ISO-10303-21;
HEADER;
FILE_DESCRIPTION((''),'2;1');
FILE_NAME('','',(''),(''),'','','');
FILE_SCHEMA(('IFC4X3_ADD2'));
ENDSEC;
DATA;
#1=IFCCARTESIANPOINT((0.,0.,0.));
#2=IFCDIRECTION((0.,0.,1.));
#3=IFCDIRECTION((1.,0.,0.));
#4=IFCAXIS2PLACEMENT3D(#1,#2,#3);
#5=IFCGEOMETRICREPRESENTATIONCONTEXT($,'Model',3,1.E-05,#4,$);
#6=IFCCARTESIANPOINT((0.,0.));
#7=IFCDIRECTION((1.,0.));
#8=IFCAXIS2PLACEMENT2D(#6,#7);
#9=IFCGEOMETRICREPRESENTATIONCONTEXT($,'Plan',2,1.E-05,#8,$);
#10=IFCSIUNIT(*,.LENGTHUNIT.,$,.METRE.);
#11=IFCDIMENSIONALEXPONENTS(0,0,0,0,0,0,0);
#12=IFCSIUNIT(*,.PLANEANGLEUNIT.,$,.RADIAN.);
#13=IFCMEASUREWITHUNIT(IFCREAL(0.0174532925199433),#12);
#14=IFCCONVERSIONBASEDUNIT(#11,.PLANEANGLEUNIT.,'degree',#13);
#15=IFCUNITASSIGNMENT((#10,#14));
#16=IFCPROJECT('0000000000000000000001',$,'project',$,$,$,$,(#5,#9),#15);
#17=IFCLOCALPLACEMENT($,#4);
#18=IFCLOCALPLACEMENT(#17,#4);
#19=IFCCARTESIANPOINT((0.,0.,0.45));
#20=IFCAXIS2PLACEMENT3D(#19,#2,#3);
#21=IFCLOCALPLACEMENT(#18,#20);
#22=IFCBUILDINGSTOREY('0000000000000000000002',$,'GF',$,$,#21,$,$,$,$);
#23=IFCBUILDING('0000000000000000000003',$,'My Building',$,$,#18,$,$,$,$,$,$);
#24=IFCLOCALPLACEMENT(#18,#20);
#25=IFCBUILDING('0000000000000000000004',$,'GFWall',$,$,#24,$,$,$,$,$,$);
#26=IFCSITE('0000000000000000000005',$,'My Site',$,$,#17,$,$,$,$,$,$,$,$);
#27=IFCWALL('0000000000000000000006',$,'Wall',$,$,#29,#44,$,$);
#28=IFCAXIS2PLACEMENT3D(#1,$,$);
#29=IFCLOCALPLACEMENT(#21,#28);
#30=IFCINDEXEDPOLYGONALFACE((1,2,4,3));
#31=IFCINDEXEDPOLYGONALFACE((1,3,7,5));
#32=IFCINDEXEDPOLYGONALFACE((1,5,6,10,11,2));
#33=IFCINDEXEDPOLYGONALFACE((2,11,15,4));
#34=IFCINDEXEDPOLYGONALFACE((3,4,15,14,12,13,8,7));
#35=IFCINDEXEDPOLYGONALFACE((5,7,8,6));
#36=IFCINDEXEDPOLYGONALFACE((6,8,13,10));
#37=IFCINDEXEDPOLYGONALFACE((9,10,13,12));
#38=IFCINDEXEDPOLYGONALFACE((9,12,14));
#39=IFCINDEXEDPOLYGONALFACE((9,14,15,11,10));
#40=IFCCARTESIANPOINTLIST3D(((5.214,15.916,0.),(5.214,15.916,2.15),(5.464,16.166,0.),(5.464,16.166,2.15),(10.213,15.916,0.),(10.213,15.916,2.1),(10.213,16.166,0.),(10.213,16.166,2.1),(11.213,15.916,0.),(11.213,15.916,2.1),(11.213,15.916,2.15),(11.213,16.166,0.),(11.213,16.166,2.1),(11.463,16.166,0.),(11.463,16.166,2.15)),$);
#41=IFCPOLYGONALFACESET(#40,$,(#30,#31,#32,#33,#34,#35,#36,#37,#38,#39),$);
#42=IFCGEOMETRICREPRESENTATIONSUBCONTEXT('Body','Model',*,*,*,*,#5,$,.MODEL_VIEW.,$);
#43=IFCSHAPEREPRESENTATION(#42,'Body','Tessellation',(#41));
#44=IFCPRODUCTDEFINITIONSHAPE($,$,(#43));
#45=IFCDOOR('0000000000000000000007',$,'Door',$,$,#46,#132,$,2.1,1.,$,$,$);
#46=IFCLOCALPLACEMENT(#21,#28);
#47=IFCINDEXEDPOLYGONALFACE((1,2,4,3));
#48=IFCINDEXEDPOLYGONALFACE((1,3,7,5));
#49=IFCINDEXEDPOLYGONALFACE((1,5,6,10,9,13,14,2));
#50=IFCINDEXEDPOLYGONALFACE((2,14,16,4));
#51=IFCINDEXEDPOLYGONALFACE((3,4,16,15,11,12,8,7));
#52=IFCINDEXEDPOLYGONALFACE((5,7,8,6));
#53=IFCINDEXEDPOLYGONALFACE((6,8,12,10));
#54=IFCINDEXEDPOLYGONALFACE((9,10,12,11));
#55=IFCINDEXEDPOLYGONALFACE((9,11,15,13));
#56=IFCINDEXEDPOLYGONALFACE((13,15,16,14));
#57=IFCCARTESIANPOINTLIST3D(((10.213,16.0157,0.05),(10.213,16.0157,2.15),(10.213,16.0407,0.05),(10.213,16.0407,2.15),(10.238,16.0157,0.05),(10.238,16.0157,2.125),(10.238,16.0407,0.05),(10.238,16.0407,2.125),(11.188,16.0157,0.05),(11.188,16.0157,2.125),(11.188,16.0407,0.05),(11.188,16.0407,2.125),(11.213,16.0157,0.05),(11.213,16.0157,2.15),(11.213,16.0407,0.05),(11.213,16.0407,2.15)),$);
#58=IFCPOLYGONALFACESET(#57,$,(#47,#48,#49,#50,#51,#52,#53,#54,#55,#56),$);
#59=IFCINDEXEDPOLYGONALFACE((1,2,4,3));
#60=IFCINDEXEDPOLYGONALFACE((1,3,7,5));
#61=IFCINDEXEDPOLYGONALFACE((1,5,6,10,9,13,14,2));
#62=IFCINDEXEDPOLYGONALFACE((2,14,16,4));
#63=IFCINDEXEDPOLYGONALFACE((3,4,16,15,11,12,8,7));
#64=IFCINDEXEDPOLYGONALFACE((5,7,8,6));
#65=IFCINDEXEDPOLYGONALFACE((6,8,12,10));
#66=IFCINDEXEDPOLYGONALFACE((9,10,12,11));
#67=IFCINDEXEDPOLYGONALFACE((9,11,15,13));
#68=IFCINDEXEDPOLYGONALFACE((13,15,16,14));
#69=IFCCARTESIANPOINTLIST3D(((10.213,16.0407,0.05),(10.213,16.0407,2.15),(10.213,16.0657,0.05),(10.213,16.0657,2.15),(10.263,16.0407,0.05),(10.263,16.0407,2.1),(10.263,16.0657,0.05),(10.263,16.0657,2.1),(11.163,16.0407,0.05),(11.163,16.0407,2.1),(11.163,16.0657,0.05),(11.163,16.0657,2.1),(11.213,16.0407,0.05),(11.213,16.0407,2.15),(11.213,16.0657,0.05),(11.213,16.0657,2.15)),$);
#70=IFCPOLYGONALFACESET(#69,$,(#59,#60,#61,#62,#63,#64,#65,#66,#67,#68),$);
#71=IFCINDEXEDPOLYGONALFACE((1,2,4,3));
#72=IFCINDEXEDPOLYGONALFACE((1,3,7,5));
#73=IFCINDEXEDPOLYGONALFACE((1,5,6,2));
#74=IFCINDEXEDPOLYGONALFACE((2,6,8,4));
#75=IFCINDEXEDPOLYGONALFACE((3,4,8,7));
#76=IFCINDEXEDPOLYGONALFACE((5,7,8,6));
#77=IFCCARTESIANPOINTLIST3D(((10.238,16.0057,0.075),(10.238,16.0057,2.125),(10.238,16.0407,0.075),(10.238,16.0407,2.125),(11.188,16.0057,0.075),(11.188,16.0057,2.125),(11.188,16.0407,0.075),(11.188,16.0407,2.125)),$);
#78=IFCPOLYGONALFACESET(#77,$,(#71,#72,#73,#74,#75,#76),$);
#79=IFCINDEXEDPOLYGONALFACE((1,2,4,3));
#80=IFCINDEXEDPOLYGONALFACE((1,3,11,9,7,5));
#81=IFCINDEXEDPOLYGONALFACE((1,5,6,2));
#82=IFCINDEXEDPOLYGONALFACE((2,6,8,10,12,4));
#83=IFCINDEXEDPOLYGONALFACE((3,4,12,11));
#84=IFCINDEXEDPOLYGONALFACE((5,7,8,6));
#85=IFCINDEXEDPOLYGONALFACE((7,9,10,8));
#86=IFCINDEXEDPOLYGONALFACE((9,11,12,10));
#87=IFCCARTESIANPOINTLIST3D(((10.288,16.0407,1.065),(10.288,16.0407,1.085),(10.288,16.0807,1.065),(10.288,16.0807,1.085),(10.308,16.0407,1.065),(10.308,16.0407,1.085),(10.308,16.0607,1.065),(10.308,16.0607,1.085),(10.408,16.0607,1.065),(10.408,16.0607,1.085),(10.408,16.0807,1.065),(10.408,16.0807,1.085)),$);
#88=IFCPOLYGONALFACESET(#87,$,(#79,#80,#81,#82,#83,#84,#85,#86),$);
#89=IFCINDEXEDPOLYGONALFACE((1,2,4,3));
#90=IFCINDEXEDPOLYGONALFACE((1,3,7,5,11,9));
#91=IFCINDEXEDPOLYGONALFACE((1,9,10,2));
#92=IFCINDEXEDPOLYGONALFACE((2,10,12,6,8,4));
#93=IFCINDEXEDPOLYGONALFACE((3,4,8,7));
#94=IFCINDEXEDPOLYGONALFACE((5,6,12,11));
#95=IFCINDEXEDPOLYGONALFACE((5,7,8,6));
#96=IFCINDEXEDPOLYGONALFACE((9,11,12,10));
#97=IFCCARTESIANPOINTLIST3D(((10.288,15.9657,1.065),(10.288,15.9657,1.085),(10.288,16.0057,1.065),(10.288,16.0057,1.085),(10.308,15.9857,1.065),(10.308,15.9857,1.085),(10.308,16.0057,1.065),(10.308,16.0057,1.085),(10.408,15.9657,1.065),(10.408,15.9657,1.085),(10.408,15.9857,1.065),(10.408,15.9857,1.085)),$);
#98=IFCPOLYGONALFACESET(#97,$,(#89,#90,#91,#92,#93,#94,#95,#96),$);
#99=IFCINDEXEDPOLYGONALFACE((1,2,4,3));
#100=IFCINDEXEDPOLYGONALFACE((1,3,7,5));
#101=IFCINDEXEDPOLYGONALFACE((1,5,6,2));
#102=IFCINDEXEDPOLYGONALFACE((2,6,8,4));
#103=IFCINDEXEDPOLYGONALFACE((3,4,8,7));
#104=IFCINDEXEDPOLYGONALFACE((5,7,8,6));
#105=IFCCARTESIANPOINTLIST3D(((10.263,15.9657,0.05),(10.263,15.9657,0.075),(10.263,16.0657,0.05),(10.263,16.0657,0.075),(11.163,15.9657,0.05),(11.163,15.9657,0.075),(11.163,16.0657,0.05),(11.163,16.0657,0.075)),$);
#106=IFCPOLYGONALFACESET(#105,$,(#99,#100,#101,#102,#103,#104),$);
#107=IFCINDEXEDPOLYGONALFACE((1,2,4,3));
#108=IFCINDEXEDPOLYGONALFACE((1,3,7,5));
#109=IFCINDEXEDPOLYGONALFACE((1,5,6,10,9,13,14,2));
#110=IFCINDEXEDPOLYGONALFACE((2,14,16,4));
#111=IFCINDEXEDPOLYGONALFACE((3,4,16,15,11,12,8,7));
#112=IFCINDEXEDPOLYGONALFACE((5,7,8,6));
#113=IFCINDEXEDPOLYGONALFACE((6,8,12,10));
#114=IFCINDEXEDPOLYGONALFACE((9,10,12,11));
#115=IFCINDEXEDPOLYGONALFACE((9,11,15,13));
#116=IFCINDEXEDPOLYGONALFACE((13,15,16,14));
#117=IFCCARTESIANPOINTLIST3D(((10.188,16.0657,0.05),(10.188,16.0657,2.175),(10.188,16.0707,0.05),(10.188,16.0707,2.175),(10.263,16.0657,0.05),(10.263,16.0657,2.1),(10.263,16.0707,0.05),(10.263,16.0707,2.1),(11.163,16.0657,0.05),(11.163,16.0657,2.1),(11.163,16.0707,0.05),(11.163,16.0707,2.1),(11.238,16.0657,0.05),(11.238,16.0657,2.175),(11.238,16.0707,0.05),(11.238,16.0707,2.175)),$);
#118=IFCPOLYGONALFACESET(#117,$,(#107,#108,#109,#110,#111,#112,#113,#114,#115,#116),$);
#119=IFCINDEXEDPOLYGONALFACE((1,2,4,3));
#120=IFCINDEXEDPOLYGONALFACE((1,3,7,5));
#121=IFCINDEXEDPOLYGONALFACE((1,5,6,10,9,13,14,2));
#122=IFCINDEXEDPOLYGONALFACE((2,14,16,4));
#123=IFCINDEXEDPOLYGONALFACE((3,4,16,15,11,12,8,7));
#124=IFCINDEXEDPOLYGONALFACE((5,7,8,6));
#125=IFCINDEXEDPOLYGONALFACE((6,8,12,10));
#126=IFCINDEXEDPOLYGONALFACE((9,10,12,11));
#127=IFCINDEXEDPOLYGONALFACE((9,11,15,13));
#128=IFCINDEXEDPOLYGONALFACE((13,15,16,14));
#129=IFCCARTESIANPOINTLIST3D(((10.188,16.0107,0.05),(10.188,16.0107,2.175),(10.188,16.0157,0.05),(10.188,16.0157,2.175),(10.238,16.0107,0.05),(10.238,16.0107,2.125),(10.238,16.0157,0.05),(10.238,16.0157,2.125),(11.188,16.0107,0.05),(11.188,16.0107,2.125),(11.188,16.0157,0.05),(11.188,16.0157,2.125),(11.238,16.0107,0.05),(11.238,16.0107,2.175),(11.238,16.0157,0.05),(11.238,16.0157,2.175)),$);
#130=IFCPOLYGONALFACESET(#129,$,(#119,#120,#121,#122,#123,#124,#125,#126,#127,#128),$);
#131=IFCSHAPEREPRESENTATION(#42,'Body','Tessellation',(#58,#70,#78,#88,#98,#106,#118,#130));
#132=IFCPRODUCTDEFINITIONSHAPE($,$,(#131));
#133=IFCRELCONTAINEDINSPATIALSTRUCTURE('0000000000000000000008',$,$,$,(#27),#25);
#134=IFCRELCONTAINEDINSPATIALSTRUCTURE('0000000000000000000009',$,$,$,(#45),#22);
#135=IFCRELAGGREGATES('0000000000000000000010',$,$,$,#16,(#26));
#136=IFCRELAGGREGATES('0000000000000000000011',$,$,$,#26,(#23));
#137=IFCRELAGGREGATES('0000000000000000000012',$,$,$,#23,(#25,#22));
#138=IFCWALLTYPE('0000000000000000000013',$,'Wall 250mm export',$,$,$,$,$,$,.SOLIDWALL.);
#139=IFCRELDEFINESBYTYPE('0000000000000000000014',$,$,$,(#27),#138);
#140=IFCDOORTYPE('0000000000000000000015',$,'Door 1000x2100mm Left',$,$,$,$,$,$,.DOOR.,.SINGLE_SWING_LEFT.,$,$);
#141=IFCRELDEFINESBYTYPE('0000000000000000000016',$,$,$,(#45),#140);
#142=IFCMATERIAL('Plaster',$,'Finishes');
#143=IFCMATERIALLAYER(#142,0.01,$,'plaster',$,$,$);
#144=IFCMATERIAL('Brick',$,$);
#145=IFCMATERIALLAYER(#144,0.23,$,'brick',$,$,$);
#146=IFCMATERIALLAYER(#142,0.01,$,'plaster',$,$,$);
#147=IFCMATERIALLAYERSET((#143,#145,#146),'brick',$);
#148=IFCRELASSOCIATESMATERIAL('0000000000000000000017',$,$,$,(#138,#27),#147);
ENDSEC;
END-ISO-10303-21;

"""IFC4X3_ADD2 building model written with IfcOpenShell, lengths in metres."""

from ifc_helpers import new_model, entity, si_unit, converted_unit, frame, origin_with_axes, origin_2d_with_axis, place, context, subcontext, project, spatial, line, indexed_curve, outline, extrude, shape, source, transform, mapped, material, layer, layer_set, layer_usage, type_object, type_shapes, element, fill, save


model = new_model("IFC4X3_ADD2")

# Units and contexts
model_context = context("Model", 3, precision=1e-05, world=origin_with_axes())
plan_context = context("Plan", 2, precision=1e-05, world=origin_2d_with_axis())
body_context_1 = subcontext(model_context, "Body", "Model", "MODEL_VIEW")
body_context_2 = subcontext(plan_context, "Body", "Plan", "PLAN_VIEW")
ifc_project = project(units=[si_unit("LENGTHUNIT", "METRE"), converted_unit("PLANEANGLEUNIT", "degree", entity("IfcReal", 0.0174532925199433), si_unit("PLANEANGLEUNIT", "RADIAN"), dimensions=[0, 0, 0, 0, 0, 0, 0])], contexts=[model_context, plan_context])

# Site, buildings
site_placement = place(None, origin_with_axes())
site = spatial("IfcSite", under=ifc_project, at=site_placement, Name="My Site")
building_1_placement = place(site_placement, origin_with_axes())
building_1 = spatial("IfcBuilding", under=site, at=building_1_placement, Name="My Building")
building_2_placement = place(building_1_placement, frame((0.0, 0.0, 0.45), z_axis=(0.0, 0.0, 1.0), x_axis=(1.0, 0.0, 0.0)))
building_2 = spatial("IfcBuilding", under=building_1, at=building_2_placement, Name="GFWall")

# Shared definitions
ifc_material_1 = material(Name="Plaster", Category="Finishes")

# Shared definitions
storey_placement = place(building_1_placement, frame((0.0, 0.0, 0.45), z_axis=(0.0, 0.0, 1.0), x_axis=(1.0, 0.0, 0.0)))
storey = spatial("IfcBuildingStorey", under=building_1, at=storey_placement, Name="GF")

# Shared definitions
ifc_layer_1 = layer(ifc_material_1, 0.01, Name="plaster")
ifc_material_2 = material(Name="Brick")
ifc_layer_2 = layer(ifc_material_2, 0.23, Name="brick")
ifc_layer_3 = layer(ifc_material_1, 0.01, Name="plaster")
ifc_layer_set_1 = layer_set([ifc_layer_1, ifc_layer_2, ifc_layer_3], Name="brick")
wall_type_1 = type_object("IfcWallType", Name="Wall 250mm export", PredefinedType="SOLIDWALL", material=ifc_layer_set_1)

# Wall, opening, door
ifc_layer_usage_1 = layer_usage(ifc_layer_set_1, "AXIS2", "POSITIVE", 0.0)
wall_1_placement = place(building_2_placement, frame((5.464, 15.916, 0.0), z_axis=(0.0, 0.0, 1.0), x_axis=(1.0, 0.0, 0.0)))
wall_1 = element("IfcWall", 1, at=wall_1_placement, inside=building_2, type_object=wall_type_1, material=ifc_layer_usage_1, Name="Wall", context=body_context_1, shape_type="SweptSolid", body=[
    extrude(outline(indexed_curve([(-0.25, 0.0), (0.0, 0.25), (5.999, 0.25), (5.749, 0.0)], segments=[line(1, 2, 3, 4, 1)])), origin_with_axes(), (0.0, 0.0, 1.0), 2.15),
])
shared_shape_1 = source(origin_with_axes(), body_context_1, "Body", "SweptSolid", [
    extrude(outline(indexed_curve([(0.0, 0.0), (1.0, 0.0), (1.0, 2.1), (0.0, 2.1)], segments=[line(1, 2, 3, 4, 1)])), frame((0.0, -0.6, 0.0), z_axis=(0.0, -1.0, 0.0), x_axis=(1.0, 0.0, 0.0)), (0.0, 0.0, -1.0), 1.2),
])
opening_1_placement = place(wall_1_placement, frame((5.749, 0.1497, 0.0), z_axis=(0.0, 0.0, 1.0), x_axis=(-1.0, 0.0, 0.0)))
opening_1 = element("IfcOpeningElement", 2, at=opening_1_placement, cuts=wall_1, PredefinedType="OPENING", context=body_context_1, shape_type="MappedRepresentation", body=[
    mapped(shared_shape_1, transform((0.0, 0.0, 0.0), x_axis=(1.0, 0.0, 0.0), y_axis=(0.0, 1.0, 0.0), z_axis=(0.0, 0.0, 1.0), scale=1.0)),
])
door_type_1 = type_object("IfcDoorType", Name="Door 1000x2100mm Left", OperationType="SINGLE_SWING_LEFT", PredefinedType="DOOR")
shared_shape_2 = source(origin_with_axes(), body_context_1, "Body", "SweptSolid", [
    extrude(outline(indexed_curve([(0.0, 0.0), (0.0, 2.1), (1.0, 2.1), (1.0, 0.0), (0.975, 0.0), (0.975, 2.075), (0.025, 2.075), (0.025, 0.0)], segments=[line(1, 2, 3, 4, 5, 6, 7, 8, 1)])), frame((0.0, 0.025, 0.0), z_axis=(0.0, -1.0, 0.0), x_axis=(1.0, 0.0, 0.0)), (0.0, 0.0, -1.0), 0.025),
    extrude(outline(indexed_curve([(0.0, 0.0), (0.0, 2.1), (1.0, 2.1), (1.0, 0.0), (0.95, 0.0), (0.95, 2.05), (0.05, 2.05), (0.05, 0.0)], segments=[line(1, 2, 3, 4, 5, 6, 7, 8, 1)])), frame((0.0, 0.0, 0.0), z_axis=(0.0, -1.0, 0.0), x_axis=(1.0, 0.0, 0.0)), (0.0, 0.0, -1.0), 0.025),
    extrude(outline(indexed_curve([(0.0, 0.0), (0.95, 0.0), (0.95, 0.035), (0.0, 0.035)], segments=[line(1, 2, 3, 4, 1)])), frame((0.025, 0.025, 0.025), z_axis=(0.0, 0.0, 1.0), x_axis=(1.0, 0.0, 0.0)), (0.0, 0.0, 1.0), 2.05),
    extrude(outline(indexed_curve([(0.0, 0.0), (0.0, -0.04), (-0.12, -0.04), (-0.12, -0.02), (-0.02, -0.02), (-0.02, 0.0)], segments=[line(1, 2, 3, 4, 5, 6, 1)])), frame((0.925, 0.025, 1.015), z_axis=(0.0, 0.0, 1.0), x_axis=(1.0, 0.0, 0.0)), (0.0, 0.0, 1.0), 0.02),
    extrude(outline(indexed_curve([(0.0, 0.0), (0.0, 0.04), (-0.12, 0.04), (-0.12, 0.02), (-0.02, 0.02), (-0.02, 0.0)], segments=[line(1, 2, 3, 4, 5, 6, 1)])), frame((0.925, 0.06, 1.015), z_axis=(0.0, 0.0, 1.0), x_axis=(1.0, 0.0, 0.0)), (0.0, 0.0, 1.0), 0.02),
    extrude(outline(indexed_curve([(0.0, 0.0), (0.9, 0.0), (0.9, 0.1), (0.0, 0.1)], segments=[line(1, 2, 3, 4, 1)])), frame((0.05, 0.0, 0.0), z_axis=(0.0, 0.0, 1.0), x_axis=(1.0, 0.0, 0.0)), (0.0, 0.0, 1.0), 0.025),
    extrude(outline(indexed_curve([(0.0, 0.0), (0.0, 2.125), (1.05, 2.125), (1.05, 0.0), (0.975, 0.0), (0.975, 2.05), (0.075, 2.05), (0.075, 0.0)], segments=[line(1, 2, 3, 4, 5, 6, 7, 8, 1)])), frame((-0.025, -0.005, 0.0), z_axis=(0.0, -1.0, 0.0), x_axis=(1.0, 0.0, 0.0)), (0.0, 0.0, -1.0), 0.005),
    extrude(outline(indexed_curve([(0.0, 0.0), (0.0, 2.125), (1.05, 2.125), (1.05, 0.0), (1.0, 0.0), (1.0, 2.075), (0.05, 2.075), (0.05, 0.0)], segments=[line(1, 2, 3, 4, 5, 6, 7, 8, 1)])), frame((-0.025, 0.05, 0.0), z_axis=(0.0, -1.0, 0.0), x_axis=(1.0, 0.0, 0.0)), (0.0, 0.0, -1.0), 0.005),
])
shared_shape_3 = source(origin_with_axes(), body_context_2, "Body", "Curve2D", [
    entity("IfcIndexedPolyCurve", entity("IfcCartesianPointList2D", [[0.0, 0.0], [0.0, 0.05], [0.025, 0.05], [0.025, 0.025], [0.05, 0.025], [0.05, 0.0]]), [entity("IfcLineIndex", [1, 2, 3, 4, 5, 6, 1])]),
    entity("IfcIndexedPolyCurve", entity("IfcCartesianPointList2D", [[1.0, 0.0], [1.0, 0.05], [0.975, 0.05], [0.975, 0.025], [0.95, 0.025], [0.95, 0.0]]), [entity("IfcLineIndex", [1, 2, 3, 4, 5, 6, 1])]),
    entity("IfcTrimmedCurve", entity("IfcEllipse", entity("IfcAxis2Placement2D", entity("IfcCartesianPoint", [0.06, 0.05]), entity("IfcDirection", [1.0, 0.0])), 0.915, 0.95), [entity("IfcCartesianPoint", [0.975, 0.05])], [entity("IfcCartesianPoint", [0.06, 1.0])], True, "CARTESIAN"),
    entity("IfcIndexedPolyCurve", entity("IfcCartesianPointList2D", [[0.025, 0.05], [0.06, 0.05], [0.06, 1.0], [0.025, 1.0]]), [entity("IfcLineIndex", [1, 2, 3, 4, 1])]),
])
type_shapes(door_type_1, [shared_shape_2, shared_shape_3])
door_1_placement = place(opening_1_placement, frame((0.0, 0.0, 0.05), z_axis=(0.0, 0.0, 1.0), x_axis=(1.0, 0.0, 0.0)))
door_1 = element("IfcDoor", 3, at=door_1_placement, inside=storey, type_object=door_type_1, Name="Door", OverallHeight=2.1, OverallWidth=1.0, shapes=[
    shape(body_context_1, "Body", "MappedRepresentation", [mapped(shared_shape_2, transform((0.0, 0.0, 0.0), x_axis=(1.0, 0.0, 0.0), y_axis=(0.0, 1.0, 0.0), z_axis=(0.0, 0.0, 1.0), scale=1.0))]),
    shape(body_context_2, "Body", "MappedRepresentation", [mapped(shared_shape_3, transform((0.0, 0.0, 0.0), x_axis=(1.0, 0.0, 0.0), y_axis=(0.0, 1.0, 0.0), z_axis=(0.0, 0.0, 1.0), scale=1.0))]),
])
fill(opening_1, door_1)

save(model, "model.ifc")
